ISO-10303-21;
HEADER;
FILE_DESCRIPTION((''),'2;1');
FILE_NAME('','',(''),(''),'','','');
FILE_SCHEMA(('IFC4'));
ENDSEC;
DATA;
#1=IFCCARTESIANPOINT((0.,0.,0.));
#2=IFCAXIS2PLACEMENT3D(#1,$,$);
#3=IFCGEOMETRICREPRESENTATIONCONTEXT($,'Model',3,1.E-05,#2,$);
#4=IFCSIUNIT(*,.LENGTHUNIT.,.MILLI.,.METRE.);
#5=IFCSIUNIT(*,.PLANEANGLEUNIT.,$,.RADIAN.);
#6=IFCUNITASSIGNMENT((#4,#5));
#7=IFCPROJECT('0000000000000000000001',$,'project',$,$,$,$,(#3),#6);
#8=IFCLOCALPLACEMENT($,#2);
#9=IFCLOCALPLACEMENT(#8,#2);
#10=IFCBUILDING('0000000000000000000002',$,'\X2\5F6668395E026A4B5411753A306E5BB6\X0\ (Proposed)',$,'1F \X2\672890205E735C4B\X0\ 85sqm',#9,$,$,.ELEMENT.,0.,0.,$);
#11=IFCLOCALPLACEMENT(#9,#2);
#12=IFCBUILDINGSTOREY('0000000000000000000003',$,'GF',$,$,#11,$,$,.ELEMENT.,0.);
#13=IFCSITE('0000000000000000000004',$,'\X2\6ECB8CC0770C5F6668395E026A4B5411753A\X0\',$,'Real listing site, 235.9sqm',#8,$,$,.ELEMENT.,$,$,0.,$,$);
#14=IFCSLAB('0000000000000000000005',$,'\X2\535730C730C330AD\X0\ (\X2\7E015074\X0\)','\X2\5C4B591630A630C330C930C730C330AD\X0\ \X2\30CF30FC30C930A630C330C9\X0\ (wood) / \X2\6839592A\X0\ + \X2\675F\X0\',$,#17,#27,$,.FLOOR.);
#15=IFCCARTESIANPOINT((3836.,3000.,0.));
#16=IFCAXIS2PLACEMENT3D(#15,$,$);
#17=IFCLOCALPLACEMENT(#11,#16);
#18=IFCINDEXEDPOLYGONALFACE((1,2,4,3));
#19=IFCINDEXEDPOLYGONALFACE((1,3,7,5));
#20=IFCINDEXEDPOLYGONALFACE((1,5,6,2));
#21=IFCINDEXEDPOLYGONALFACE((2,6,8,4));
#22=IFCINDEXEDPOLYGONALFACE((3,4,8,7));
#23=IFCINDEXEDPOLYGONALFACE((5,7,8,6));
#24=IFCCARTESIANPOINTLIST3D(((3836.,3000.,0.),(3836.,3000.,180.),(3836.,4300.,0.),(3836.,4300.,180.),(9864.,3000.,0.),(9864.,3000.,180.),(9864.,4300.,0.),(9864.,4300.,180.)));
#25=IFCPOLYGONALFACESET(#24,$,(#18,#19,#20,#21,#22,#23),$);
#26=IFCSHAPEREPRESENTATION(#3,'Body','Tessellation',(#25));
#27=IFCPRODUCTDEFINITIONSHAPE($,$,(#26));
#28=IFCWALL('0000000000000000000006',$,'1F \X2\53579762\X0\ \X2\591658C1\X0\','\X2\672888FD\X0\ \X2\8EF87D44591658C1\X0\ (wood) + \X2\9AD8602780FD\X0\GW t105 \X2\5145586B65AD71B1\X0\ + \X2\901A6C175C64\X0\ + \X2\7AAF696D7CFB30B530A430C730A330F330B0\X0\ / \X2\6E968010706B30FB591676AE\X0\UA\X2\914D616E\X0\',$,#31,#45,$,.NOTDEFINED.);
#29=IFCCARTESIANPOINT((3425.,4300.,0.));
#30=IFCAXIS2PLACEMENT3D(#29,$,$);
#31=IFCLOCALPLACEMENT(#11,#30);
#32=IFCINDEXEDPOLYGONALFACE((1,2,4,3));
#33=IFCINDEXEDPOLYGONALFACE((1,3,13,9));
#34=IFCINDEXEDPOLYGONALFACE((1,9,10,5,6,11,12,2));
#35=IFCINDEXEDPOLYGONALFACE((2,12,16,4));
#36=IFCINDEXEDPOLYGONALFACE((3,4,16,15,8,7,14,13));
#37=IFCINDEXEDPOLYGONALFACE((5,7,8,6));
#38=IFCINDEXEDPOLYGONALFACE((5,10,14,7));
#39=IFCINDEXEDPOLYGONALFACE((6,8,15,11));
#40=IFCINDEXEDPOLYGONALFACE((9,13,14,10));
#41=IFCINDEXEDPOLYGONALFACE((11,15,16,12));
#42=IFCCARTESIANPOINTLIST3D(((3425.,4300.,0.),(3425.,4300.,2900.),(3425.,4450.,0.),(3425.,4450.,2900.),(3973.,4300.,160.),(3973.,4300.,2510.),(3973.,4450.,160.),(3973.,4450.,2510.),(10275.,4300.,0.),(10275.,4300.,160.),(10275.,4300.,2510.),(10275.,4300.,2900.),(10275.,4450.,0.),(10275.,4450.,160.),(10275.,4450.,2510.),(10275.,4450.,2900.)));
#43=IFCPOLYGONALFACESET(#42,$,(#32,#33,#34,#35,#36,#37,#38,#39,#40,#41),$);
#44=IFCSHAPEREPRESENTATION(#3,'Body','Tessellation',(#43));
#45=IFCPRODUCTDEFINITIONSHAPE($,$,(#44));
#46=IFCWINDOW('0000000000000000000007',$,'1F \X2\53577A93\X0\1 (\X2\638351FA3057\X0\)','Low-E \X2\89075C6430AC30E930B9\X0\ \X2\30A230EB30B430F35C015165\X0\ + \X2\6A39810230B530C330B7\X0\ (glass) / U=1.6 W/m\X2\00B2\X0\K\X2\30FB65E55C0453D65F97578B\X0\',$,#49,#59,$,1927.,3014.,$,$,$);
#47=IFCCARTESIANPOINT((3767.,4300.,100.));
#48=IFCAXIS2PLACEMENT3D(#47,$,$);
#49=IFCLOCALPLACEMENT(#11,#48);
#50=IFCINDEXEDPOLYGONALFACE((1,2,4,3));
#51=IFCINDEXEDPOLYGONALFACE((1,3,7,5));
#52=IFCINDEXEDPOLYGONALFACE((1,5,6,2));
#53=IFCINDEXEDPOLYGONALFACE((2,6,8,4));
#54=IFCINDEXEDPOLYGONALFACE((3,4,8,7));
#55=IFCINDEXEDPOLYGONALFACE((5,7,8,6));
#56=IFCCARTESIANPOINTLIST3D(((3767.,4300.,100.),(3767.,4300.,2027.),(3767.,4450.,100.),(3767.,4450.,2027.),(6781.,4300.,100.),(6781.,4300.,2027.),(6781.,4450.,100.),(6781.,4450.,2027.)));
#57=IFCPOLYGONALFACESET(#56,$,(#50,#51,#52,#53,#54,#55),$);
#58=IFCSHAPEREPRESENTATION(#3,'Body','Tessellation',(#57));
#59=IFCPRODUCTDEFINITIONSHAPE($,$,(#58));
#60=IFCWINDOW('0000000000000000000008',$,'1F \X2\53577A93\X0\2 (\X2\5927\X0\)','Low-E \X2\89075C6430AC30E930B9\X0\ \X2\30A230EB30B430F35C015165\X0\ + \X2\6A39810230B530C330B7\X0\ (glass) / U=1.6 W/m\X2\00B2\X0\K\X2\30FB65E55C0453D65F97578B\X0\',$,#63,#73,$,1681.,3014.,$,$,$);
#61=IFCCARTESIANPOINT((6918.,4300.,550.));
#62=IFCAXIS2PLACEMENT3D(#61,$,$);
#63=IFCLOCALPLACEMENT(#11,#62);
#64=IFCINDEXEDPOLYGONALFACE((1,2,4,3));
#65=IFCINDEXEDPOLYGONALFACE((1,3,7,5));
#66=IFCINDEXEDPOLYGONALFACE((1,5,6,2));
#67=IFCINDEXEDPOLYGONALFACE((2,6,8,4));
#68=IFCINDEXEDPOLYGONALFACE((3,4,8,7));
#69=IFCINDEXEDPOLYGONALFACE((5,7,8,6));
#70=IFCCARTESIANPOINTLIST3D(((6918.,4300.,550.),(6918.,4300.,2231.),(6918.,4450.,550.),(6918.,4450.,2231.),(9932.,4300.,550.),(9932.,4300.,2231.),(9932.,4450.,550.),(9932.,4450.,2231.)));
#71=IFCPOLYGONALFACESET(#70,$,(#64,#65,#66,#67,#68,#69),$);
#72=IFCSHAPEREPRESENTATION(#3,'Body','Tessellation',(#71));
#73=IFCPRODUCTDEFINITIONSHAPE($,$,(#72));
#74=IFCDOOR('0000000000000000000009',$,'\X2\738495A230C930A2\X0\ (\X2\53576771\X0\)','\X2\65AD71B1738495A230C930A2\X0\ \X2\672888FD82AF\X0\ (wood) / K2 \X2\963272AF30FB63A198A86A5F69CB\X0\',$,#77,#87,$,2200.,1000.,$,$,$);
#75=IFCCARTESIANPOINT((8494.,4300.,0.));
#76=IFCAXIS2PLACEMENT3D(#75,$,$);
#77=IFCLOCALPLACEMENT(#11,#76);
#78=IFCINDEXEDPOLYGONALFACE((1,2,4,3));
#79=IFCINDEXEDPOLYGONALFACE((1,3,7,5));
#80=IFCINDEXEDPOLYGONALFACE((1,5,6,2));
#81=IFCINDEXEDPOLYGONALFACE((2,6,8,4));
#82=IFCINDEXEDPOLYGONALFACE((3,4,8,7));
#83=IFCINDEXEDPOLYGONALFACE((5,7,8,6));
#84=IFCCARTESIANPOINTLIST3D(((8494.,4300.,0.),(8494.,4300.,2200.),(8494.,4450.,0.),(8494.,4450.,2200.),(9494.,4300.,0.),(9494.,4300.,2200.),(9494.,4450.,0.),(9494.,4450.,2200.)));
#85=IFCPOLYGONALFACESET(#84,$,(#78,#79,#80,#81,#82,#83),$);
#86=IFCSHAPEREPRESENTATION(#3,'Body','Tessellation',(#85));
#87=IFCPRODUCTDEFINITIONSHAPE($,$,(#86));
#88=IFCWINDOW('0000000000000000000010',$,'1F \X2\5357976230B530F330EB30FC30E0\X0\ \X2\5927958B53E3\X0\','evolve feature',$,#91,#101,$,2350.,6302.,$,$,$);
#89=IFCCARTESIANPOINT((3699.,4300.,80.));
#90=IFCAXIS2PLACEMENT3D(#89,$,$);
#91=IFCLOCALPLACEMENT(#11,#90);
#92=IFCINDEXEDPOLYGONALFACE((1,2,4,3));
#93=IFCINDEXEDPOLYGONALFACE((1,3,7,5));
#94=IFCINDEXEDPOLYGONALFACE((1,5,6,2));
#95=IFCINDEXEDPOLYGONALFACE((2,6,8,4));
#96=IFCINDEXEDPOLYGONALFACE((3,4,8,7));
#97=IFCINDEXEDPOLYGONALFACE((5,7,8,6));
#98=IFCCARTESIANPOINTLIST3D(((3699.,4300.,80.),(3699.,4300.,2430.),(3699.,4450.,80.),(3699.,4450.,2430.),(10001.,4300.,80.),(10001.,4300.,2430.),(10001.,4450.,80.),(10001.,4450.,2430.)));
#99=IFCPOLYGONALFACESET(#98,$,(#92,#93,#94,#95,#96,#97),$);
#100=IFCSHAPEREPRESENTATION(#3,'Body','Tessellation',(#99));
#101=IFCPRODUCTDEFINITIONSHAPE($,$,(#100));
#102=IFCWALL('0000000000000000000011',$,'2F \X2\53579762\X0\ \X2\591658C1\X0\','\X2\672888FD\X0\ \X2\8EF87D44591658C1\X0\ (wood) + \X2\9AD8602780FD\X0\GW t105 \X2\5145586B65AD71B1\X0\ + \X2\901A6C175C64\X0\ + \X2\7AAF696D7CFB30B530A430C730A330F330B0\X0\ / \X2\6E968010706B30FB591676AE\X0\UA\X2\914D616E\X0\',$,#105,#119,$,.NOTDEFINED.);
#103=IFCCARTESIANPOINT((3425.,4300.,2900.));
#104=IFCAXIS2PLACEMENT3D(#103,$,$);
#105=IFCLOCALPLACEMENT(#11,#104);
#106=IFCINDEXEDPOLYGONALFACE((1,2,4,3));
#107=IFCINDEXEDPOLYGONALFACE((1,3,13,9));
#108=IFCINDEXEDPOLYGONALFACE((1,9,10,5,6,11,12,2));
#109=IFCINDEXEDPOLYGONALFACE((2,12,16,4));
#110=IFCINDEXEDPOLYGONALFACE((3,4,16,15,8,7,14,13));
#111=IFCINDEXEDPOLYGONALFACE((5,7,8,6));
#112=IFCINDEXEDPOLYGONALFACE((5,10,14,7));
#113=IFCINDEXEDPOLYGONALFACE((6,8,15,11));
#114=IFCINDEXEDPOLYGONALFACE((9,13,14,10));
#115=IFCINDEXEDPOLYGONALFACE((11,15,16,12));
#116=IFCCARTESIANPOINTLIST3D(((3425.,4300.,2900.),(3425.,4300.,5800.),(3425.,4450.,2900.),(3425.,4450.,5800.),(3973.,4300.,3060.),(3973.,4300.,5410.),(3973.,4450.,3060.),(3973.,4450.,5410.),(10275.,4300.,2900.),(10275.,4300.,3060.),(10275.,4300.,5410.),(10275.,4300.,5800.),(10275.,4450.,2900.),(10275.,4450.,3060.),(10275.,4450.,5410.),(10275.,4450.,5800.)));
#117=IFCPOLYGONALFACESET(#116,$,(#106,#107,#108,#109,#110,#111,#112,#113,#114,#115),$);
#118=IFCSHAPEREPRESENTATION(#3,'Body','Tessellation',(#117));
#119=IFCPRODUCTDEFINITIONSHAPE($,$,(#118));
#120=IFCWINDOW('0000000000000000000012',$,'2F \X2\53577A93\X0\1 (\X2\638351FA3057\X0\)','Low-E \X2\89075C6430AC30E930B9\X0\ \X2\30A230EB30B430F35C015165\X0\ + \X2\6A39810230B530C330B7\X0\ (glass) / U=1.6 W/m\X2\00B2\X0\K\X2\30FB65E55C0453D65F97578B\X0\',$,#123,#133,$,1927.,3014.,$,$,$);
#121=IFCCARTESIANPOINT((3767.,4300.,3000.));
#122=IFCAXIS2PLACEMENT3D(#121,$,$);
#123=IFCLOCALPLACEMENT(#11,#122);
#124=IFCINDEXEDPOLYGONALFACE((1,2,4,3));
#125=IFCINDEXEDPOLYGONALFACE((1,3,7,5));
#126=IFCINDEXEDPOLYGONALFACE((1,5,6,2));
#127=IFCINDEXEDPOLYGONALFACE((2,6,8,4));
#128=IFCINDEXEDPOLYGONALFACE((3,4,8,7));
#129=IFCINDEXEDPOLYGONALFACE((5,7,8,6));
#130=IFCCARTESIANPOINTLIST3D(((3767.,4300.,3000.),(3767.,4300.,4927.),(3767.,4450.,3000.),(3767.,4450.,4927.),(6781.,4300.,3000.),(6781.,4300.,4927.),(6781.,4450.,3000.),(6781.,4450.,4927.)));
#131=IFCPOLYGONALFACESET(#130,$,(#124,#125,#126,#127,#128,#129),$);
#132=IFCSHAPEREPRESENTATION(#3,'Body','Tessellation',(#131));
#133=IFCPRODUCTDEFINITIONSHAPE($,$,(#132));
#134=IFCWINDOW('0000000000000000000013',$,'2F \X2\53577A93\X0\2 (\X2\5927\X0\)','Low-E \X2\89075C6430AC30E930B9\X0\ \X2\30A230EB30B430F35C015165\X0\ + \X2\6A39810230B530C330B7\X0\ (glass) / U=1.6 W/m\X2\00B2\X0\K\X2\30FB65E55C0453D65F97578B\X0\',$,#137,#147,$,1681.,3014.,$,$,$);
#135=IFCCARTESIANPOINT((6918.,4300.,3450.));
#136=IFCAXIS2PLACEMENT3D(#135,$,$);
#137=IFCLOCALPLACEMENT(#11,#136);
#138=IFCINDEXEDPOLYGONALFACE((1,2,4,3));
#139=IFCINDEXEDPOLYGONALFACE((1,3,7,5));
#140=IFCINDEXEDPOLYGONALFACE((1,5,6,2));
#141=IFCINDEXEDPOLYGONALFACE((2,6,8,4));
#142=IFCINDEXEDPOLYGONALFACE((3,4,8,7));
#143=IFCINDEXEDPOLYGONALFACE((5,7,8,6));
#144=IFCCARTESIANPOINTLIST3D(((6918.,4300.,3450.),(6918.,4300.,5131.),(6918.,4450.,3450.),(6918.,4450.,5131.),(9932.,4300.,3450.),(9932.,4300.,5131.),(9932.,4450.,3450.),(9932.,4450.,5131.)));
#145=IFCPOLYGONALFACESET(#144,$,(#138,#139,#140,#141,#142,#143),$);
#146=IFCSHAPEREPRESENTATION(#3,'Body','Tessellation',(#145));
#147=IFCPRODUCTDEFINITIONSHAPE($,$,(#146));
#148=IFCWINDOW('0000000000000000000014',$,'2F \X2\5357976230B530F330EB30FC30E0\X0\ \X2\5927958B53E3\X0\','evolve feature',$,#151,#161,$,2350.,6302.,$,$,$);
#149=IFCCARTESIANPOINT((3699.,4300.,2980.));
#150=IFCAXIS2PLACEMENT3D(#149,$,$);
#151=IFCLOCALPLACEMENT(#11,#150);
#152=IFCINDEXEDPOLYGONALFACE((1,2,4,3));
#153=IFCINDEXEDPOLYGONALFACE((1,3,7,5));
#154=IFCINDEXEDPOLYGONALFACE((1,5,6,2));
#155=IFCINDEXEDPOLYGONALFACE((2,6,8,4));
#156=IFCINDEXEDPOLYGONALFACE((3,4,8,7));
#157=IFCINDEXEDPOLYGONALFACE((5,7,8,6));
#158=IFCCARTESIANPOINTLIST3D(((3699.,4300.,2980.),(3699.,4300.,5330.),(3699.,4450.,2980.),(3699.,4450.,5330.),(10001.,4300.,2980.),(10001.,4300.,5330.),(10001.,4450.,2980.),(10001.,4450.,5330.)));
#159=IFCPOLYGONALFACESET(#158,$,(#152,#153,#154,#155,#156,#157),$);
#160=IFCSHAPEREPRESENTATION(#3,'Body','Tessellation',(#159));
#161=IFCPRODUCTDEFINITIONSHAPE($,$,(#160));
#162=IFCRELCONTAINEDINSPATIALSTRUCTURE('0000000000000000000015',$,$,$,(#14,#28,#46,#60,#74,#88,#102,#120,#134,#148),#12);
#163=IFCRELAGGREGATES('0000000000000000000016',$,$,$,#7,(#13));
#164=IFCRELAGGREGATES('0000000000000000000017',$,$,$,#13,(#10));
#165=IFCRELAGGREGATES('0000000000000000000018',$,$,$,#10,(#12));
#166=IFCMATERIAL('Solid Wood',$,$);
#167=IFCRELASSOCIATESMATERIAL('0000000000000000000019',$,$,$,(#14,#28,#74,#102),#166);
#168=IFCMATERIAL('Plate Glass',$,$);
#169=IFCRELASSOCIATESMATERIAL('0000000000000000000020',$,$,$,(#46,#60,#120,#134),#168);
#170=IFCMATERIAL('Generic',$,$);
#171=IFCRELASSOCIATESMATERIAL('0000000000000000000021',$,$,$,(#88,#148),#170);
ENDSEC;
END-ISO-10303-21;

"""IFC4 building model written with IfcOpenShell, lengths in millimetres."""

from ifc_helpers import new_model, si_unit, frame, frame_2d, origin, place, context, project, spatial, rectangle, extrude, material, element, fill, save


model = new_model("IFC4")

# Units and contexts
model_context = context("Model", 3, precision=1e-05, world=origin())
ifc_project = project(units=[si_unit("LENGTHUNIT", "METRE", prefix="MILLI"), si_unit("PLANEANGLEUNIT", "RADIAN")], contexts=[model_context])

# Site, building, storey
site_placement = place(None, origin())
site = spatial("IfcSite", under=ifc_project, at=site_placement, Name="滋賀県彦根市橋向町", ObjectType="Real listing site, 235.9sqm", CompositionType="ELEMENT", RefElevation=0.0)
building_placement = place(site_placement, origin())
building = spatial("IfcBuilding", under=site, at=building_placement, Name="彦根市橋向町の家 (Proposed)", ObjectType="1F 木造平屋 85sqm", CompositionType="ELEMENT", ElevationOfRefHeight=0.0, ElevationOfTerrain=0.0)
storey_placement = place(building_placement, origin())
storey = spatial("IfcBuildingStorey", under=building, at=storey_placement, Name="GF", CompositionType="ELEMENT", Elevation=0.0)

# Slab
ifc_material_1 = material(Name="Solid Wood")
slab_1_placement = place(storey_placement, frame((3836.0, 3000.0, 0.0)))
element("IfcSlab", 1, at=slab_1_placement, inside=storey, material=ifc_material_1, Name="南デッキ (縁側)", Description="屋外ウッドデッキ ハードウッド (wood) / 根太 + 束", PredefinedType="FLOOR", context=model_context, shape_type="SweptSolid", body=[
    extrude(rectangle(XDim=6028.0, YDim=1300.0, at=frame_2d((3014.0, 650.0))), frame((3836.0, 3000.0, 0.0)), (0.0, 0.0, 1.0), 180.0),
])
ifc_material_2 = material(Name="Generic")

# Wall, openings, windows, door
wall_1_placement = place(storey_placement, frame((3425.0, 4300.0, 0.0)))
wall_1 = element("IfcWall", 2, at=wall_1_placement, inside=storey, material=ifc_material_1, Name="1F 南面 外壁", Description="木製 軸組外壁 (wood) + 高性能GW t105 充填断熱 + 通気層 + 窯業系サイディング / 準耐火・外皮UA配慮", PredefinedType="NOTDEFINED", context=model_context, shape_type="SweptSolid", body=[
    extrude(rectangle(XDim=6850.0, YDim=150.0, at=frame_2d((3425.0, 75.0))), frame((3425.0, 4300.0, 0.0)), (0.0, 0.0, 1.0), 2900.0),
])
opening_1_placement = place(storey_placement, frame((3767.0, 4300.0, 100.0)))
opening_1 = element("IfcOpeningElement", 3, at=opening_1_placement, cuts=wall_1, PredefinedType="NOTDEFINED", context=model_context, shape_type="SweptSolid", body=[
    extrude(rectangle(XDim=3014.0, YDim=150.0, at=frame_2d((1507.0, 75.0))), frame((3767.0, 4300.0, 100.0)), (0.0, 0.0, 1.0), 1927.0),
])
opening_2_placement = place(storey_placement, frame((6918.0, 4300.0, 550.0)))
opening_2 = element("IfcOpeningElement", 4, at=opening_2_placement, cuts=wall_1, PredefinedType="NOTDEFINED", context=model_context, shape_type="SweptSolid", body=[
    extrude(rectangle(XDim=3014.0, YDim=150.0, at=frame_2d((1507.0, 75.0))), frame((6918.0, 4300.0, 550.0)), (0.0, 0.0, 1.0), 1681.0),
])
opening_3_placement = place(storey_placement, frame((8494.0, 4300.0, 0.0)))
opening_3 = element("IfcOpeningElement", 5, at=opening_3_placement, cuts=wall_1, PredefinedType="NOTDEFINED", context=model_context, shape_type="SweptSolid", body=[
    extrude(rectangle(XDim=1000.0, YDim=150.0, at=frame_2d((500.0, 75.0))), frame((8494.0, 4300.0, 0.0)), (0.0, 0.0, 1.0), 2200.0),
])
opening_4_placement = place(storey_placement, frame((3699.0, 4300.0, 80.0)))
opening_4 = element("IfcOpeningElement", 6, at=opening_4_placement, cuts=wall_1, PredefinedType="NOTDEFINED", context=model_context, shape_type="SweptSolid", body=[
    extrude(rectangle(XDim=6302.0, YDim=150.0, at=frame_2d((3151.0, 75.0))), frame((3699.0, 4300.0, 80.0)), (0.0, 0.0, 1.0), 2350.0),
])
ifc_material_3 = material(Name="Plate Glass")
window_1_placement = place(storey_placement, frame((3767.0, 4300.0, 100.0)))
window_1 = element("IfcWindow", 7, at=window_1_placement, inside=storey, material=ifc_material_3, Name="1F 南窓1 (掃出し)", Description="Low-E 複層ガラス アルゴン封入 + 樹脂サッシ (glass) / U=1.6 W/m²K・日射取得型", OverallHeight=1927.0, OverallWidth=3014.0, context=model_context, shape_type="SweptSolid", body=[
    extrude(rectangle(XDim=3014.0, YDim=150.0, at=frame_2d((1507.0, 75.0))), frame((3767.0, 4300.0, 100.0)), (0.0, 0.0, 1.0), 1927.0),
])
fill(opening_1, window_1)
window_2_placement = place(storey_placement, frame((6918.0, 4300.0, 550.0)))
window_2 = element("IfcWindow", 8, at=window_2_placement, inside=storey, material=ifc_material_3, Name="1F 南窓2 (大)", Description="Low-E 複層ガラス アルゴン封入 + 樹脂サッシ (glass) / U=1.6 W/m²K・日射取得型", OverallHeight=1681.0, OverallWidth=3014.0, context=model_context, shape_type="SweptSolid", body=[
    extrude(rectangle(XDim=3014.0, YDim=150.0, at=frame_2d((1507.0, 75.0))), frame((6918.0, 4300.0, 550.0)), (0.0, 0.0, 1.0), 1681.0),
])
fill(opening_2, window_2)
door_placement = place(storey_placement, frame((8494.0, 4300.0, 0.0)))
door = element("IfcDoor", 9, at=door_placement, inside=storey, material=ifc_material_1, Name="玄関ドア (南東)", Description="断熱玄関ドア 木製芯 (wood) / K2 防犯・採風機構", OverallHeight=2200.0, OverallWidth=1000.0, context=model_context, shape_type="SweptSolid", body=[
    extrude(rectangle(XDim=1000.0, YDim=150.0, at=frame_2d((500.0, 75.0))), frame((8494.0, 4300.0, 0.0)), (0.0, 0.0, 1.0), 2200.0),
])
fill(opening_3, door)
window_3_placement = place(storey_placement, frame((3699.0, 4300.0, 80.0)))
window_3 = element("IfcWindow", 10, at=window_3_placement, inside=storey, material=ifc_material_2, Name="1F 南面サンルーム 大開口", Description="evolve feature", OverallHeight=2350.0, OverallWidth=6302.0, context=model_context, shape_type="SweptSolid", body=[
    extrude(rectangle(XDim=6302.0, YDim=150.0, at=frame_2d((3151.0, 75.0))), frame((3699.0, 4300.0, 80.0)), (0.0, 0.0, 1.0), 2350.0),
])
fill(opening_4, window_3)

# Wall, openings, windows
wall_2_placement = place(storey_placement, frame((3425.0, 4300.0, 2900.0)))
wall_2 = element("IfcWall", 11, at=wall_2_placement, inside=storey, material=ifc_material_1, Name="2F 南面 外壁", Description="木製 軸組外壁 (wood) + 高性能GW t105 充填断熱 + 通気層 + 窯業系サイディング / 準耐火・外皮UA配慮", PredefinedType="NOTDEFINED", context=model_context, shape_type="SweptSolid", body=[
    extrude(rectangle(XDim=6850.0, YDim=150.0, at=frame_2d((3425.0, 75.0))), frame((3425.0, 4300.0, 2900.0)), (0.0, 0.0, 1.0), 2900.0),
])
opening_5_placement = place(storey_placement, frame((3767.0, 4300.0, 3000.0)))
opening_5 = element("IfcOpeningElement", 12, at=opening_5_placement, cuts=wall_2, PredefinedType="NOTDEFINED", context=model_context, shape_type="SweptSolid", body=[
    extrude(rectangle(XDim=3014.0, YDim=150.0, at=frame_2d((1507.0, 75.0))), frame((3767.0, 4300.0, 3000.0)), (0.0, 0.0, 1.0), 1927.0),
])
opening_6_placement = place(storey_placement, frame((6918.0, 4300.0, 3450.0)))
opening_6 = element("IfcOpeningElement", 13, at=opening_6_placement, cuts=wall_2, PredefinedType="NOTDEFINED", context=model_context, shape_type="SweptSolid", body=[
    extrude(rectangle(XDim=3014.0, YDim=150.0, at=frame_2d((1507.0, 75.0))), frame((6918.0, 4300.0, 3450.0)), (0.0, 0.0, 1.0), 1681.0),
])
opening_7_placement = place(storey_placement, frame((3699.0, 4300.0, 2980.0)))
opening_7 = element("IfcOpeningElement", 14, at=opening_7_placement, cuts=wall_2, PredefinedType="NOTDEFINED", context=model_context, shape_type="SweptSolid", body=[
    extrude(rectangle(XDim=6302.0, YDim=150.0, at=frame_2d((3151.0, 75.0))), frame((3699.0, 4300.0, 2980.0)), (0.0, 0.0, 1.0), 2350.0),
])
window_4_placement = place(storey_placement, frame((3767.0, 4300.0, 3000.0)))
window_4 = element("IfcWindow", 15, at=window_4_placement, inside=storey, material=ifc_material_3, Name="2F 南窓1 (掃出し)", Description="Low-E 複層ガラス アルゴン封入 + 樹脂サッシ (glass) / U=1.6 W/m²K・日射取得型", OverallHeight=1927.0, OverallWidth=3014.0, context=model_context, shape_type="SweptSolid", body=[
    extrude(rectangle(XDim=3014.0, YDim=150.0, at=frame_2d((1507.0, 75.0))), frame((3767.0, 4300.0, 3000.0)), (0.0, 0.0, 1.0), 1927.0),
])
fill(opening_5, window_4)
window_5_placement = place(storey_placement, frame((6918.0, 4300.0, 3450.0)))
window_5 = element("IfcWindow", 16, at=window_5_placement, inside=storey, material=ifc_material_3, Name="2F 南窓2 (大)", Description="Low-E 複層ガラス アルゴン封入 + 樹脂サッシ (glass) / U=1.6 W/m²K・日射取得型", OverallHeight=1681.0, OverallWidth=3014.0, context=model_context, shape_type="SweptSolid", body=[
    extrude(rectangle(XDim=3014.0, YDim=150.0, at=frame_2d((1507.0, 75.0))), frame((6918.0, 4300.0, 3450.0)), (0.0, 0.0, 1.0), 1681.0),
])
fill(opening_6, window_5)
window_6_placement = place(storey_placement, frame((3699.0, 4300.0, 2980.0)))
window_6 = element("IfcWindow", 17, at=window_6_placement, inside=storey, material=ifc_material_2, Name="2F 南面サンルーム 大開口", Description="evolve feature", OverallHeight=2350.0, OverallWidth=6302.0, context=model_context, shape_type="SweptSolid", body=[
    extrude(rectangle(XDim=6302.0, YDim=150.0, at=frame_2d((3151.0, 75.0))), frame((3699.0, 4300.0, 2980.0)), (0.0, 0.0, 1.0), 2350.0),
])
fill(opening_7, window_6)

save(model, "model.ifc")
